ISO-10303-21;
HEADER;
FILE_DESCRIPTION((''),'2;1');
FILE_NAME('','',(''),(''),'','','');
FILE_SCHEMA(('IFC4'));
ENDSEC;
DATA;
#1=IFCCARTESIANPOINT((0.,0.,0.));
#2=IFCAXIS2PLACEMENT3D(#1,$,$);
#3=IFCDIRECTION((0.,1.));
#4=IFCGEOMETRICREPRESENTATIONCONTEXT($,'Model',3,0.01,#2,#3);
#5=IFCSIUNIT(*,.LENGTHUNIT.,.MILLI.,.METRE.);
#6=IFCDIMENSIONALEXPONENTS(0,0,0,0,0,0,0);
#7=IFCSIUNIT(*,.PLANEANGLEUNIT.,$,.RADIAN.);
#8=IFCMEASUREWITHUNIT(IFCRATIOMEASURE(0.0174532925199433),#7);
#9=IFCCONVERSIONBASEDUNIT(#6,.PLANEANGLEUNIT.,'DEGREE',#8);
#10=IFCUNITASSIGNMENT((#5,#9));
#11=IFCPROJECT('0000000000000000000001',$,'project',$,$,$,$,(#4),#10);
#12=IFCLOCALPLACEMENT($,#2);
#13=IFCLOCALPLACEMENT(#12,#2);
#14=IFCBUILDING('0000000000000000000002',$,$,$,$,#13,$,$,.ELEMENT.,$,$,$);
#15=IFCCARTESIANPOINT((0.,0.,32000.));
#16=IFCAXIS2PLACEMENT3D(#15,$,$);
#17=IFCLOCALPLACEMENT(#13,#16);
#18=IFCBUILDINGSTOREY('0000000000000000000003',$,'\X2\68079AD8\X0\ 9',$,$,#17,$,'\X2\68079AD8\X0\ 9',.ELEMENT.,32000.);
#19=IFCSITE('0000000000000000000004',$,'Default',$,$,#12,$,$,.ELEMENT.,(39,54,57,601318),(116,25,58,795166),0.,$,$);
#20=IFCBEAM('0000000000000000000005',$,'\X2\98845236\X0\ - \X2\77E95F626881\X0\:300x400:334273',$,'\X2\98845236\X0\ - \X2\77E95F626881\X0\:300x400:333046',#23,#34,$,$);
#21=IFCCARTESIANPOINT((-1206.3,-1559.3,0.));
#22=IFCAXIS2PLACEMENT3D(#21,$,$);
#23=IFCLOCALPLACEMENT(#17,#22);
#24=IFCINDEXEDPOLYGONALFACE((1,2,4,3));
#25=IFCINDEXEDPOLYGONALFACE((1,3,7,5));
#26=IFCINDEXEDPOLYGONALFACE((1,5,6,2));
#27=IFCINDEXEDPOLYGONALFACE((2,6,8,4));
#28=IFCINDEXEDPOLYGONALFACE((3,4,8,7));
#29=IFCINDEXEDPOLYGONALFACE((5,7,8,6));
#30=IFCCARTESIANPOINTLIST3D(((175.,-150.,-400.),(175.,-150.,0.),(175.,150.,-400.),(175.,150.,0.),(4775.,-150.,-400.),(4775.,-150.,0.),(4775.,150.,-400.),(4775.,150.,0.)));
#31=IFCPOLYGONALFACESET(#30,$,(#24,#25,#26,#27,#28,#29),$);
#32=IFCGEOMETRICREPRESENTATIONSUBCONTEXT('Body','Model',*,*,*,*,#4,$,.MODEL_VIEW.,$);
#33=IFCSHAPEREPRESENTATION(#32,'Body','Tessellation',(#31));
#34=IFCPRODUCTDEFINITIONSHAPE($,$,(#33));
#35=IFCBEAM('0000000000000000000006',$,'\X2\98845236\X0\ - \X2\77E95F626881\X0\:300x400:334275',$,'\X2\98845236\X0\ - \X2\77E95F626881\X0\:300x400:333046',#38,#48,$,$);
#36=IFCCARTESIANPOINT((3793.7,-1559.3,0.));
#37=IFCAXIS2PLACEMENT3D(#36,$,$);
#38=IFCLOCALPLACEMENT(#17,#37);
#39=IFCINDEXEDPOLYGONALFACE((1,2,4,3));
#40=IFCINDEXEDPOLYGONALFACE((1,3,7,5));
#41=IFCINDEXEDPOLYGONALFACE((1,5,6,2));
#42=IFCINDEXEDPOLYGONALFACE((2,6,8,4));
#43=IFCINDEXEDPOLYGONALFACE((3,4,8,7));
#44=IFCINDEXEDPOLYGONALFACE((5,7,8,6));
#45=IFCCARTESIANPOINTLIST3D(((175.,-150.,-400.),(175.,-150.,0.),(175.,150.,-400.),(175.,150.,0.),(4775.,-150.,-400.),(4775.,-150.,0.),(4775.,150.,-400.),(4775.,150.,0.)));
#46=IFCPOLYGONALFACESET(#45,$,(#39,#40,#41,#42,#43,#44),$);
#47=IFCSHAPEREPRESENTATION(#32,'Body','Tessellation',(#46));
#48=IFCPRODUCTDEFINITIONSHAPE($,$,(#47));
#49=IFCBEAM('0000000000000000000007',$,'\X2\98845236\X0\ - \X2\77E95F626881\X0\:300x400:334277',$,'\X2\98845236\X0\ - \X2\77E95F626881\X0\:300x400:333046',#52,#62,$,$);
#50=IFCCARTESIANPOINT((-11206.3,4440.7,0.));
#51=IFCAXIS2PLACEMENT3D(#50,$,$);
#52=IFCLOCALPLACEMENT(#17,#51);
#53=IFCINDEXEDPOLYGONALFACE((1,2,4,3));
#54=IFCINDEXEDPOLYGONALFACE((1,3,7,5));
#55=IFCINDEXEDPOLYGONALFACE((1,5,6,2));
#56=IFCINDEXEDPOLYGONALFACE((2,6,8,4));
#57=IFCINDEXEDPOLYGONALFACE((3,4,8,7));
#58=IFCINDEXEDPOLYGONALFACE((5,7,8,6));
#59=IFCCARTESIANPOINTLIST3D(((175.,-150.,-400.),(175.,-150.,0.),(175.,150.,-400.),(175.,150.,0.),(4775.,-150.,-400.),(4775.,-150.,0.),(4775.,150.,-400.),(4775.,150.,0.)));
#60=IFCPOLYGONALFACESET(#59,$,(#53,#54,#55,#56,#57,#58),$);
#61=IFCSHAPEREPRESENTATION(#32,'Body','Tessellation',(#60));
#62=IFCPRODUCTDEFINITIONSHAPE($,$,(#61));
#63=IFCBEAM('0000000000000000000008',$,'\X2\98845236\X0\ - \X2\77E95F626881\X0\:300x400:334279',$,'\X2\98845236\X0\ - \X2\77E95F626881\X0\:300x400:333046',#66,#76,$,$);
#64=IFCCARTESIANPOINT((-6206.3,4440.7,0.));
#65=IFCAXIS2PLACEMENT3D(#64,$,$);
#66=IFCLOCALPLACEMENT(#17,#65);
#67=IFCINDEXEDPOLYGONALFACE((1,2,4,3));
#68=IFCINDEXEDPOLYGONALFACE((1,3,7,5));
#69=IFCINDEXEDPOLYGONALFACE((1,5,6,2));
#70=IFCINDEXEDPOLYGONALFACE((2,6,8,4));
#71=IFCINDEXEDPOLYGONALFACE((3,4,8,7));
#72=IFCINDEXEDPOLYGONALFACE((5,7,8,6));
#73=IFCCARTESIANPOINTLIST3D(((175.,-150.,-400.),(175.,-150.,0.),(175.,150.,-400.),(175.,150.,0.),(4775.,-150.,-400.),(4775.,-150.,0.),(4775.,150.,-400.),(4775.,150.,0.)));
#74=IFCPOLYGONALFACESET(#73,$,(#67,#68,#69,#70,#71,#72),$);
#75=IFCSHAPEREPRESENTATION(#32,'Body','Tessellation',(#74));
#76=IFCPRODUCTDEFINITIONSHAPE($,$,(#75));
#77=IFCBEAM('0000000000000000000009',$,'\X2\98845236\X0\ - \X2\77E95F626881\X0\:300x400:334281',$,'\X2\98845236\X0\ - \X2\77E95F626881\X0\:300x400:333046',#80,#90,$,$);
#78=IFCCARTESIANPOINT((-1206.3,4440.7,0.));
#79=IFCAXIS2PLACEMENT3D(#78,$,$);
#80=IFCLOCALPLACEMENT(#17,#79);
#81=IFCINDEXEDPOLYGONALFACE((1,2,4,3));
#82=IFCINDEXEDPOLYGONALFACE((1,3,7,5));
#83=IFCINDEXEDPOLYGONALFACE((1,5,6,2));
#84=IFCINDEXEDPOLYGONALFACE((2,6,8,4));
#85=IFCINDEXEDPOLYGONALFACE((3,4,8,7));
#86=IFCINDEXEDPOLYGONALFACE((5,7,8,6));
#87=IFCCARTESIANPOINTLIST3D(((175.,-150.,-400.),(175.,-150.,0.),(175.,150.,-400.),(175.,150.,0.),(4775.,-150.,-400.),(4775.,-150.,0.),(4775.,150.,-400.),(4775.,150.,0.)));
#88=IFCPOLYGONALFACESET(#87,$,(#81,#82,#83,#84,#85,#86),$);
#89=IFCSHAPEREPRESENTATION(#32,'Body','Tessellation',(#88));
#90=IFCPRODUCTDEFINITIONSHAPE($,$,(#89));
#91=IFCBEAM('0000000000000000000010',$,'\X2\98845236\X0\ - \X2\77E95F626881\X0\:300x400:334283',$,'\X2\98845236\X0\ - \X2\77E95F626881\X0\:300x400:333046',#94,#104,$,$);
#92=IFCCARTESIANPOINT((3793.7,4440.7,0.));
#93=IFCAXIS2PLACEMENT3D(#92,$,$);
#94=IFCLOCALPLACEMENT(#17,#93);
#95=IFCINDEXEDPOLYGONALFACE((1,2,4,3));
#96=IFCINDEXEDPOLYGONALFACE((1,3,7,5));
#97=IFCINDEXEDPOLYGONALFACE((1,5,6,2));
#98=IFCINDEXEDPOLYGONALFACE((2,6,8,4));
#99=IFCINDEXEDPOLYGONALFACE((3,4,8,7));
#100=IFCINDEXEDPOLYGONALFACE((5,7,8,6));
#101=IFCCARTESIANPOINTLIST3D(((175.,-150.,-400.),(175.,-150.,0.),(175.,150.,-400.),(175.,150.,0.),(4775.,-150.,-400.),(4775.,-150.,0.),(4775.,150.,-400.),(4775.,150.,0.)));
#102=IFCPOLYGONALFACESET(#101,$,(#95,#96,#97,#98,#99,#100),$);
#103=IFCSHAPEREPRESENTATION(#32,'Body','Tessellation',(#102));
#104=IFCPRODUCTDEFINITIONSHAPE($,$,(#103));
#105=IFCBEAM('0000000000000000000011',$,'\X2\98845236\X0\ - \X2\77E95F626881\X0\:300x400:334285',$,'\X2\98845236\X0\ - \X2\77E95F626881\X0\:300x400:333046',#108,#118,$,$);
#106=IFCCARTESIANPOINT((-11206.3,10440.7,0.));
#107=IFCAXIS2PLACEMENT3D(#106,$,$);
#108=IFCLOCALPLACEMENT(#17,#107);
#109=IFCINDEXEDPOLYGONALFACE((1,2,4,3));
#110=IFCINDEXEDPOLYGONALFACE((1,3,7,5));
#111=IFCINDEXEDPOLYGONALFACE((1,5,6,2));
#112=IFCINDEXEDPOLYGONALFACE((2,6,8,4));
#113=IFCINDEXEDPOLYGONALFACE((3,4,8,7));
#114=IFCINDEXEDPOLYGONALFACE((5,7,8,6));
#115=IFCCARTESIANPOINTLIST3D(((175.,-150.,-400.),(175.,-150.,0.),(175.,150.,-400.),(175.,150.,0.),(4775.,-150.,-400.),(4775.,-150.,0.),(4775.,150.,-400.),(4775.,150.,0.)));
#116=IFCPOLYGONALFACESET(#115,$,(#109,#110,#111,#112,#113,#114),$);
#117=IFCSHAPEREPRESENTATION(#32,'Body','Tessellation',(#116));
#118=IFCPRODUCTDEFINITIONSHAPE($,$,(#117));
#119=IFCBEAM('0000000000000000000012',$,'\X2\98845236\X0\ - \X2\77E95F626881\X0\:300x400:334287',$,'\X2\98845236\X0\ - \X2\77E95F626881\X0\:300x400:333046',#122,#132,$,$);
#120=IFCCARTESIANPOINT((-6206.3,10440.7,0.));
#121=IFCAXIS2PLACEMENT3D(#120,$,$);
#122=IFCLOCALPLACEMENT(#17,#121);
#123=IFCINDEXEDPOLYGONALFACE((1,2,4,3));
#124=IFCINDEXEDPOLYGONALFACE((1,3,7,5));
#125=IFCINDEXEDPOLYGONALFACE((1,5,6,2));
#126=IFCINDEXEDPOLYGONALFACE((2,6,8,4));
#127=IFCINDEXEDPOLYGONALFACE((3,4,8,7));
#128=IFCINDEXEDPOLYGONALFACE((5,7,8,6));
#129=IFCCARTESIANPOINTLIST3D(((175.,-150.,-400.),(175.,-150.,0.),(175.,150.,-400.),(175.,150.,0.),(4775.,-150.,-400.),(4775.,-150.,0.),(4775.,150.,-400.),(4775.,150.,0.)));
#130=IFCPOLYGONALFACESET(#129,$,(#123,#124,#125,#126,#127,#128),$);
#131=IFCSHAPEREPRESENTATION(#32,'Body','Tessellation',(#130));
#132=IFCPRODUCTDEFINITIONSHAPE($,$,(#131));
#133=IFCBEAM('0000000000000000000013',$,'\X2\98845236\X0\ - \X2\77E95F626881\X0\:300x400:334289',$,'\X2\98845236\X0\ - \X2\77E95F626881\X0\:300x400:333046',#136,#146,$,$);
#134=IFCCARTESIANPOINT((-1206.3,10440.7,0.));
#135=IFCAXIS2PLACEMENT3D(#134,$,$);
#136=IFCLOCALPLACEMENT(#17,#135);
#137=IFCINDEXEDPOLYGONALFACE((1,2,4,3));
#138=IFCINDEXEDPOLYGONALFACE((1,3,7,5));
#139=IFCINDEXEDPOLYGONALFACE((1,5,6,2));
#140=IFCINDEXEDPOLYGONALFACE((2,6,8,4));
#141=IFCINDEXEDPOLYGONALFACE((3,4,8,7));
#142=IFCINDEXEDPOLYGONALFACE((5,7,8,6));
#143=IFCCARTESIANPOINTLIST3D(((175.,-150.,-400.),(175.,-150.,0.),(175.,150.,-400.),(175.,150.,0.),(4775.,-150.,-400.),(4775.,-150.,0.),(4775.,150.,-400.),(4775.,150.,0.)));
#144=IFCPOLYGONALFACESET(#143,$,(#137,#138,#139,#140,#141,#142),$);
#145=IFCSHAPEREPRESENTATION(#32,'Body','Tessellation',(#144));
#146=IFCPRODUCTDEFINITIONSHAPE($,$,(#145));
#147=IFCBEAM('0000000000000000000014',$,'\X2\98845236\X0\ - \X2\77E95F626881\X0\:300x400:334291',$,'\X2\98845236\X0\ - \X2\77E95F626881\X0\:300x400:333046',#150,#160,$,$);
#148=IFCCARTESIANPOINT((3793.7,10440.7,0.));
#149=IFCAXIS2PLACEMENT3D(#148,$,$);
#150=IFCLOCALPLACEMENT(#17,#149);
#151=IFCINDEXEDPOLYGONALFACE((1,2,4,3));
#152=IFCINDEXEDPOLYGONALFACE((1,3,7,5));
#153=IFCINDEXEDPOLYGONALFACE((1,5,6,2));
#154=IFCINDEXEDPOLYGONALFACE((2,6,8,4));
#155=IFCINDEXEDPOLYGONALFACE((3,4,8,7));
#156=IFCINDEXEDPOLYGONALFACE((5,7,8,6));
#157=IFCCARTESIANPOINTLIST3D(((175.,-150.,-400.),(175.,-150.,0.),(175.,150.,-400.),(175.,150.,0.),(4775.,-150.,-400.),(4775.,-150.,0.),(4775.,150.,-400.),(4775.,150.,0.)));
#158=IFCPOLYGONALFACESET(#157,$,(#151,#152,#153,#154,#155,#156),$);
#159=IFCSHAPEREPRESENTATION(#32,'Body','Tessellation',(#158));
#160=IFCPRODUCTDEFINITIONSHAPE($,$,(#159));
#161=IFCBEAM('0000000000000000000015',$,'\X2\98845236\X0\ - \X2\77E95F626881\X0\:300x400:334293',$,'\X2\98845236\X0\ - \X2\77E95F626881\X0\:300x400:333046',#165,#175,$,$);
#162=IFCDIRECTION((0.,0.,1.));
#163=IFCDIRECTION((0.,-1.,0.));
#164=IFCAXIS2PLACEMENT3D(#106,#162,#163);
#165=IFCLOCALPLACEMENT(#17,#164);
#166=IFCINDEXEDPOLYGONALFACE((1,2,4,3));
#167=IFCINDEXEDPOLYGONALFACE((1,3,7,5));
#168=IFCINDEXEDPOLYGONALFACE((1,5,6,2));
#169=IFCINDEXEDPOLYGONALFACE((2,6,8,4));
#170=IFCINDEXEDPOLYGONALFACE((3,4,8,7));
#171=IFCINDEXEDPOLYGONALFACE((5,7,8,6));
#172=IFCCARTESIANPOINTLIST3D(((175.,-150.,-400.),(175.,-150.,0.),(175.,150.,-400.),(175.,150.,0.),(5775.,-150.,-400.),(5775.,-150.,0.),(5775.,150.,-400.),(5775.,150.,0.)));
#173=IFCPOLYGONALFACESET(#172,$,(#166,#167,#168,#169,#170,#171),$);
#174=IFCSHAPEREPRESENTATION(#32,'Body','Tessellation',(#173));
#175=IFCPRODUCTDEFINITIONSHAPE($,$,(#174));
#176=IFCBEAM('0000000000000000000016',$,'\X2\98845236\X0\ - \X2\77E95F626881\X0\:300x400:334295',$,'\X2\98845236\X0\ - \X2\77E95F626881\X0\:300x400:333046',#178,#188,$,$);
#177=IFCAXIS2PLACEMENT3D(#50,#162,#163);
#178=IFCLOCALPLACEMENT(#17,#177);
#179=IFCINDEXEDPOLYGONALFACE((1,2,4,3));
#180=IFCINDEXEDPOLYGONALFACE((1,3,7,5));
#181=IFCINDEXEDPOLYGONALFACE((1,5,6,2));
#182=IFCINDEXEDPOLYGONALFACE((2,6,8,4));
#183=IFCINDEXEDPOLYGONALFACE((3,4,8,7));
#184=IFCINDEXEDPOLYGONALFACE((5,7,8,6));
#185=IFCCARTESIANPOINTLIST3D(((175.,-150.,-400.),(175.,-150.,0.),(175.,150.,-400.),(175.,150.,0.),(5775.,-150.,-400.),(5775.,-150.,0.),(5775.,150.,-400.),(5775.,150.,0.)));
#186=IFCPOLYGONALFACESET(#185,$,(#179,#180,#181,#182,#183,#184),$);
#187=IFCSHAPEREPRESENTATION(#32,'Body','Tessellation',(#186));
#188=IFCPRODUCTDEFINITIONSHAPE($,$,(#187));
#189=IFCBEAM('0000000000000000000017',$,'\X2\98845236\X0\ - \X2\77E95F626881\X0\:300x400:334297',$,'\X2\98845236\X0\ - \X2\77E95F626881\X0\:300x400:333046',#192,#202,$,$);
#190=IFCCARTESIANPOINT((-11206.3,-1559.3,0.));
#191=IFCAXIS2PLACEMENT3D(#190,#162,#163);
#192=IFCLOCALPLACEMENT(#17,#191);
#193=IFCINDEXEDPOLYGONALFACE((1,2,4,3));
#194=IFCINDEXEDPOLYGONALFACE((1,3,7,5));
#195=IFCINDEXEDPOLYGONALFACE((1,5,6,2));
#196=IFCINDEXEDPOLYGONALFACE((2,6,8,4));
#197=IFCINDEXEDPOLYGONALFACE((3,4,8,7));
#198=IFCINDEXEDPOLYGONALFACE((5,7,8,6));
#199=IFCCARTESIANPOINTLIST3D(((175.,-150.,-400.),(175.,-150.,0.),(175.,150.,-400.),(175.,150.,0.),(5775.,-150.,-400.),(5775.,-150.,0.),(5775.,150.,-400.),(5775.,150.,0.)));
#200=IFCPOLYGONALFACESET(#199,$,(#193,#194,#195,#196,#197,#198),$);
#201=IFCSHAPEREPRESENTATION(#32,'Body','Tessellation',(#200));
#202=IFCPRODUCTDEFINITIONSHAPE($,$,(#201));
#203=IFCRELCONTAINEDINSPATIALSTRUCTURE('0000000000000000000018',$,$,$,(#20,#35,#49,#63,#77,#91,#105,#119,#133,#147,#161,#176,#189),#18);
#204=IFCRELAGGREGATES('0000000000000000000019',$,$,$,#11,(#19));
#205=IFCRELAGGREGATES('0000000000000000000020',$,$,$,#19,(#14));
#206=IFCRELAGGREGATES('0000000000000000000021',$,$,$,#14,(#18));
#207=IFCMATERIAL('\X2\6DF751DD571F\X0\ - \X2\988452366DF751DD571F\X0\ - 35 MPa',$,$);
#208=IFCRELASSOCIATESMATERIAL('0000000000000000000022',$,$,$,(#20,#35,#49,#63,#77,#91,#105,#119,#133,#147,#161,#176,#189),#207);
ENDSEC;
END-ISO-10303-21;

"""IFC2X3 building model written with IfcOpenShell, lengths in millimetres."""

from ifc_helpers import new_model, entity, si_unit, converted_unit, direction, frame, frame_2d, origin, origin_2d_with_axis, place, context, subcontext, project, spatial, rectangle, extrude, material, element, save


model = new_model("IFC2X3")

# Units and contexts
model_context = context("Model", 3, precision=0.01, world=origin(), true_north=direction((0.0, 1.0)))
body_context = subcontext(model_context, "Body", "Model", "MODEL_VIEW")
ifc_project = project(units=[si_unit("LENGTHUNIT", "METRE", prefix="MILLI"), converted_unit("PLANEANGLEUNIT", "DEGREE", entity("IfcRatioMeasure", 0.0174532925199433), si_unit("PLANEANGLEUNIT", "RADIAN"), dimensions=[0, 0, 0, 0, 0, 0, 0])], contexts=[model_context])

# Site, building, storey
site_placement = place(None, origin())
site = spatial("IfcSite", under=ifc_project, at=site_placement, Name="Default", CompositionType="ELEMENT", RefLatitude=(39, 54, 57, 601318), RefLongitude=(116, 25, 58, 795166), RefElevation=0.0)
building_placement = place(site_placement, origin())
building = spatial("IfcBuilding", under=site, at=building_placement, CompositionType="ELEMENT")
storey_placement = place(building_placement, frame((0.0, 0.0, 32000.0)))
storey = spatial("IfcBuildingStorey", under=building, at=storey_placement, Name="标高 9", LongName="标高 9", CompositionType="ELEMENT", Elevation=32000.0)

# Beams
ifc_material_1 = material(Name="混凝土 - 预制混凝土 - 35 MPa")
beam_1_placement = place(storey_placement, frame((-1206.3, -1559.3, 0.0)))
element("IfcBeam", 1, at=beam_1_placement, inside=storey, material=ifc_material_1, Name="预制 - 矩形梁:300x400:334273", ObjectType="预制 - 矩形梁:300x400:333046", context=body_context, shape_type="SweptSolid", body=[
    extrude(rectangle(XDim=400.0, YDim=300.0, at=frame_2d((0.0, 0.0), x_axis=(1.0, 0.0))), frame((175.0, 0.0, -200.0), z_axis=(1.0, 0.0, 0.0), x_axis=(0.0, 0.0, -1.0)), (0.0, 0.0, 1.0), 4600.0),
])
beam_2_placement = place(storey_placement, frame((3793.7, -1559.3, 0.0)))
element("IfcBeam", 2, at=beam_2_placement, inside=storey, material=ifc_material_1, Name="预制 - 矩形梁:300x400:334275", ObjectType="预制 - 矩形梁:300x400:333046", context=body_context, shape_type="SweptSolid", body=[
    extrude(rectangle(XDim=400.0, YDim=300.0, at=frame_2d((0.0, 0.0), x_axis=(1.0, 0.0))), frame((175.0, 0.0, -200.0), z_axis=(1.0, 0.0, 0.0), x_axis=(0.0, 0.0, -1.0)), (0.0, 0.0, 1.0), 4600.0),
])
beam_3_placement = place(storey_placement, frame((-11206.3, 4440.7, 0.0)))
element("IfcBeam", 3, at=beam_3_placement, inside=storey, material=ifc_material_1, Name="预制 - 矩形梁:300x400:334277", ObjectType="预制 - 矩形梁:300x400:333046", context=body_context, shape_type="SweptSolid", body=[
    extrude(rectangle(XDim=400.0, YDim=300.0, at=frame_2d((0.0, 0.0), x_axis=(1.0, 0.0))), frame((175.0, 0.0, -200.0), z_axis=(1.0, 0.0, 0.0), x_axis=(0.0, 0.0, -1.0)), (0.0, 0.0, 1.0), 4600.0),
])
beam_4_placement = place(storey_placement, frame((-6206.3, 4440.7, 0.0)))
element("IfcBeam", 4, at=beam_4_placement, inside=storey, material=ifc_material_1, Name="预制 - 矩形梁:300x400:334279", ObjectType="预制 - 矩形梁:300x400:333046", context=body_context, shape_type="SweptSolid", body=[
    extrude(rectangle(XDim=400.0, YDim=300.0, at=frame_2d((0.0, 0.0), x_axis=(1.0, 0.0))), frame((175.0, 0.0, -200.0), z_axis=(1.0, 0.0, 0.0), x_axis=(0.0, 0.0, -1.0)), (0.0, 0.0, 1.0), 4600.0),
])
beam_5_placement = place(storey_placement, frame((-1206.3, 4440.7, 0.0)))
element("IfcBeam", 5, at=beam_5_placement, inside=storey, material=ifc_material_1, Name="预制 - 矩形梁:300x400:334281", ObjectType="预制 - 矩形梁:300x400:333046", context=body_context, shape_type="SweptSolid", body=[
    extrude(rectangle(XDim=400.0, YDim=300.0, at=frame_2d((0.0, 0.0), x_axis=(1.0, 0.0))), frame((175.0, 0.0, -200.0), z_axis=(1.0, 0.0, 0.0), x_axis=(0.0, 0.0, -1.0)), (0.0, 0.0, 1.0), 4600.0),
])
beam_6_placement = place(storey_placement, frame((3793.7, 4440.7, 0.0)))
element("IfcBeam", 6, at=beam_6_placement, inside=storey, material=ifc_material_1, Name="预制 - 矩形梁:300x400:334283", ObjectType="预制 - 矩形梁:300x400:333046", context=body_context, shape_type="SweptSolid", body=[
    extrude(rectangle(XDim=400.0, YDim=300.0, at=frame_2d((0.0, 0.0), x_axis=(1.0, 0.0))), frame((175.0, 0.0, -200.0), z_axis=(1.0, 0.0, 0.0), x_axis=(0.0, 0.0, -1.0)), (0.0, 0.0, 1.0), 4600.0),
])
beam_7_placement = place(storey_placement, frame((-11206.3, 10440.7, 0.0)))
element("IfcBeam", 7, at=beam_7_placement, inside=storey, material=ifc_material_1, Name="预制 - 矩形梁:300x400:334285", ObjectType="预制 - 矩形梁:300x400:333046", context=body_context, shape_type="SweptSolid", body=[
    extrude(rectangle(XDim=400.0, YDim=300.0, at=frame_2d((0.0, 0.0), x_axis=(1.0, 0.0))), frame((175.0, 0.0, -200.0), z_axis=(1.0, 0.0, 0.0), x_axis=(0.0, 0.0, -1.0)), (0.0, 0.0, 1.0), 4600.0),
])
beam_8_placement = place(storey_placement, frame((-6206.3, 10440.7, 0.0)))
element("IfcBeam", 8, at=beam_8_placement, inside=storey, material=ifc_material_1, Name="预制 - 矩形梁:300x400:334287", ObjectType="预制 - 矩形梁:300x400:333046", context=body_context, shape_type="SweptSolid", body=[
    extrude(rectangle(XDim=400.0, YDim=300.0, at=frame_2d((0.0, 0.0), x_axis=(1.0, 0.0))), frame((175.0, 0.0, -200.0), z_axis=(1.0, 0.0, 0.0), x_axis=(0.0, 0.0, -1.0)), (0.0, 0.0, 1.0), 4600.0),
])
beam_9_placement = place(storey_placement, frame((-1206.3, 10440.7, 0.0)))
element("IfcBeam", 9, at=beam_9_placement, inside=storey, material=ifc_material_1, Name="预制 - 矩形梁:300x400:334289", ObjectType="预制 - 矩形梁:300x400:333046", context=body_context, shape_type="SweptSolid", body=[
    extrude(rectangle(XDim=400.0, YDim=300.0, at=frame_2d((0.0, 0.0), x_axis=(1.0, 0.0))), frame((175.0, 0.0, -200.0), z_axis=(1.0, 0.0, 0.0), x_axis=(0.0, 0.0, -1.0)), (0.0, 0.0, 1.0), 4600.0),
])
beam_10_placement = place(storey_placement, frame((3793.7, 10440.7, 0.0)))
element("IfcBeam", 10, at=beam_10_placement, inside=storey, material=ifc_material_1, Name="预制 - 矩形梁:300x400:334291", ObjectType="预制 - 矩形梁:300x400:333046", context=body_context, shape_type="SweptSolid", body=[
    extrude(rectangle(XDim=400.0, YDim=300.0, at=frame_2d((0.0, 0.0), x_axis=(1.0, 0.0))), frame((175.0, 0.0, -200.0), z_axis=(1.0, 0.0, 0.0), x_axis=(0.0, 0.0, -1.0)), (0.0, 0.0, 1.0), 4600.0),
])
for number, where, z_axis, x_axis, name in (
    (11, (-11206.3, 10440.7, 0.0), (0.0, 0.0, 1.0), (0.0, -1.0, 0.0), "预制 - 矩形梁:300x400:334293"),
    (12, (-11206.3, 4440.7, 0.0), (0.0, 0.0, 1.0), (0.0, -1.0, 0.0), "预制 - 矩形梁:300x400:334295"),
):
    element("IfcBeam", number, at=place(storey_placement, frame(where, z_axis=z_axis, x_axis=x_axis)), inside=storey, material=ifc_material_1, Name=name, ObjectType="预制 - 矩形梁:300x400:333046", context=body_context, shape_type="SweptSolid", body=[
        extrude(rectangle(XDim=400.0, YDim=300.0, at=origin_2d_with_axis()), frame((175.0, 0.0, -200.0), z_axis=(1.0, 0.0, 0.0), x_axis=(0.0, 0.0, -1.0)), (0.0, 0.0, 1.0), 5600.0),
    ])
beam_11_placement = place(storey_placement, frame((-11206.3, -1559.3, 0.0), z_axis=(0.0, 0.0, 1.0), x_axis=(0.0, -1.0, 0.0)))
element("IfcBeam", 13, at=beam_11_placement, inside=storey, material=ifc_material_1, Name="预制 - 矩形梁:300x400:334297", ObjectType="预制 - 矩形梁:300x400:333046", context=body_context, shape_type="SweptSolid", body=[
    extrude(rectangle(XDim=400.0, YDim=300.0, at=frame_2d((0.0, 0.0), x_axis=(1.0, 0.0))), frame((175.0, 0.0, -200.0), z_axis=(1.0, 0.0, 0.0), x_axis=(0.0, 0.0, -1.0)), (0.0, 0.0, 1.0), 5600.0),
])

save(model, "model.ifc")
